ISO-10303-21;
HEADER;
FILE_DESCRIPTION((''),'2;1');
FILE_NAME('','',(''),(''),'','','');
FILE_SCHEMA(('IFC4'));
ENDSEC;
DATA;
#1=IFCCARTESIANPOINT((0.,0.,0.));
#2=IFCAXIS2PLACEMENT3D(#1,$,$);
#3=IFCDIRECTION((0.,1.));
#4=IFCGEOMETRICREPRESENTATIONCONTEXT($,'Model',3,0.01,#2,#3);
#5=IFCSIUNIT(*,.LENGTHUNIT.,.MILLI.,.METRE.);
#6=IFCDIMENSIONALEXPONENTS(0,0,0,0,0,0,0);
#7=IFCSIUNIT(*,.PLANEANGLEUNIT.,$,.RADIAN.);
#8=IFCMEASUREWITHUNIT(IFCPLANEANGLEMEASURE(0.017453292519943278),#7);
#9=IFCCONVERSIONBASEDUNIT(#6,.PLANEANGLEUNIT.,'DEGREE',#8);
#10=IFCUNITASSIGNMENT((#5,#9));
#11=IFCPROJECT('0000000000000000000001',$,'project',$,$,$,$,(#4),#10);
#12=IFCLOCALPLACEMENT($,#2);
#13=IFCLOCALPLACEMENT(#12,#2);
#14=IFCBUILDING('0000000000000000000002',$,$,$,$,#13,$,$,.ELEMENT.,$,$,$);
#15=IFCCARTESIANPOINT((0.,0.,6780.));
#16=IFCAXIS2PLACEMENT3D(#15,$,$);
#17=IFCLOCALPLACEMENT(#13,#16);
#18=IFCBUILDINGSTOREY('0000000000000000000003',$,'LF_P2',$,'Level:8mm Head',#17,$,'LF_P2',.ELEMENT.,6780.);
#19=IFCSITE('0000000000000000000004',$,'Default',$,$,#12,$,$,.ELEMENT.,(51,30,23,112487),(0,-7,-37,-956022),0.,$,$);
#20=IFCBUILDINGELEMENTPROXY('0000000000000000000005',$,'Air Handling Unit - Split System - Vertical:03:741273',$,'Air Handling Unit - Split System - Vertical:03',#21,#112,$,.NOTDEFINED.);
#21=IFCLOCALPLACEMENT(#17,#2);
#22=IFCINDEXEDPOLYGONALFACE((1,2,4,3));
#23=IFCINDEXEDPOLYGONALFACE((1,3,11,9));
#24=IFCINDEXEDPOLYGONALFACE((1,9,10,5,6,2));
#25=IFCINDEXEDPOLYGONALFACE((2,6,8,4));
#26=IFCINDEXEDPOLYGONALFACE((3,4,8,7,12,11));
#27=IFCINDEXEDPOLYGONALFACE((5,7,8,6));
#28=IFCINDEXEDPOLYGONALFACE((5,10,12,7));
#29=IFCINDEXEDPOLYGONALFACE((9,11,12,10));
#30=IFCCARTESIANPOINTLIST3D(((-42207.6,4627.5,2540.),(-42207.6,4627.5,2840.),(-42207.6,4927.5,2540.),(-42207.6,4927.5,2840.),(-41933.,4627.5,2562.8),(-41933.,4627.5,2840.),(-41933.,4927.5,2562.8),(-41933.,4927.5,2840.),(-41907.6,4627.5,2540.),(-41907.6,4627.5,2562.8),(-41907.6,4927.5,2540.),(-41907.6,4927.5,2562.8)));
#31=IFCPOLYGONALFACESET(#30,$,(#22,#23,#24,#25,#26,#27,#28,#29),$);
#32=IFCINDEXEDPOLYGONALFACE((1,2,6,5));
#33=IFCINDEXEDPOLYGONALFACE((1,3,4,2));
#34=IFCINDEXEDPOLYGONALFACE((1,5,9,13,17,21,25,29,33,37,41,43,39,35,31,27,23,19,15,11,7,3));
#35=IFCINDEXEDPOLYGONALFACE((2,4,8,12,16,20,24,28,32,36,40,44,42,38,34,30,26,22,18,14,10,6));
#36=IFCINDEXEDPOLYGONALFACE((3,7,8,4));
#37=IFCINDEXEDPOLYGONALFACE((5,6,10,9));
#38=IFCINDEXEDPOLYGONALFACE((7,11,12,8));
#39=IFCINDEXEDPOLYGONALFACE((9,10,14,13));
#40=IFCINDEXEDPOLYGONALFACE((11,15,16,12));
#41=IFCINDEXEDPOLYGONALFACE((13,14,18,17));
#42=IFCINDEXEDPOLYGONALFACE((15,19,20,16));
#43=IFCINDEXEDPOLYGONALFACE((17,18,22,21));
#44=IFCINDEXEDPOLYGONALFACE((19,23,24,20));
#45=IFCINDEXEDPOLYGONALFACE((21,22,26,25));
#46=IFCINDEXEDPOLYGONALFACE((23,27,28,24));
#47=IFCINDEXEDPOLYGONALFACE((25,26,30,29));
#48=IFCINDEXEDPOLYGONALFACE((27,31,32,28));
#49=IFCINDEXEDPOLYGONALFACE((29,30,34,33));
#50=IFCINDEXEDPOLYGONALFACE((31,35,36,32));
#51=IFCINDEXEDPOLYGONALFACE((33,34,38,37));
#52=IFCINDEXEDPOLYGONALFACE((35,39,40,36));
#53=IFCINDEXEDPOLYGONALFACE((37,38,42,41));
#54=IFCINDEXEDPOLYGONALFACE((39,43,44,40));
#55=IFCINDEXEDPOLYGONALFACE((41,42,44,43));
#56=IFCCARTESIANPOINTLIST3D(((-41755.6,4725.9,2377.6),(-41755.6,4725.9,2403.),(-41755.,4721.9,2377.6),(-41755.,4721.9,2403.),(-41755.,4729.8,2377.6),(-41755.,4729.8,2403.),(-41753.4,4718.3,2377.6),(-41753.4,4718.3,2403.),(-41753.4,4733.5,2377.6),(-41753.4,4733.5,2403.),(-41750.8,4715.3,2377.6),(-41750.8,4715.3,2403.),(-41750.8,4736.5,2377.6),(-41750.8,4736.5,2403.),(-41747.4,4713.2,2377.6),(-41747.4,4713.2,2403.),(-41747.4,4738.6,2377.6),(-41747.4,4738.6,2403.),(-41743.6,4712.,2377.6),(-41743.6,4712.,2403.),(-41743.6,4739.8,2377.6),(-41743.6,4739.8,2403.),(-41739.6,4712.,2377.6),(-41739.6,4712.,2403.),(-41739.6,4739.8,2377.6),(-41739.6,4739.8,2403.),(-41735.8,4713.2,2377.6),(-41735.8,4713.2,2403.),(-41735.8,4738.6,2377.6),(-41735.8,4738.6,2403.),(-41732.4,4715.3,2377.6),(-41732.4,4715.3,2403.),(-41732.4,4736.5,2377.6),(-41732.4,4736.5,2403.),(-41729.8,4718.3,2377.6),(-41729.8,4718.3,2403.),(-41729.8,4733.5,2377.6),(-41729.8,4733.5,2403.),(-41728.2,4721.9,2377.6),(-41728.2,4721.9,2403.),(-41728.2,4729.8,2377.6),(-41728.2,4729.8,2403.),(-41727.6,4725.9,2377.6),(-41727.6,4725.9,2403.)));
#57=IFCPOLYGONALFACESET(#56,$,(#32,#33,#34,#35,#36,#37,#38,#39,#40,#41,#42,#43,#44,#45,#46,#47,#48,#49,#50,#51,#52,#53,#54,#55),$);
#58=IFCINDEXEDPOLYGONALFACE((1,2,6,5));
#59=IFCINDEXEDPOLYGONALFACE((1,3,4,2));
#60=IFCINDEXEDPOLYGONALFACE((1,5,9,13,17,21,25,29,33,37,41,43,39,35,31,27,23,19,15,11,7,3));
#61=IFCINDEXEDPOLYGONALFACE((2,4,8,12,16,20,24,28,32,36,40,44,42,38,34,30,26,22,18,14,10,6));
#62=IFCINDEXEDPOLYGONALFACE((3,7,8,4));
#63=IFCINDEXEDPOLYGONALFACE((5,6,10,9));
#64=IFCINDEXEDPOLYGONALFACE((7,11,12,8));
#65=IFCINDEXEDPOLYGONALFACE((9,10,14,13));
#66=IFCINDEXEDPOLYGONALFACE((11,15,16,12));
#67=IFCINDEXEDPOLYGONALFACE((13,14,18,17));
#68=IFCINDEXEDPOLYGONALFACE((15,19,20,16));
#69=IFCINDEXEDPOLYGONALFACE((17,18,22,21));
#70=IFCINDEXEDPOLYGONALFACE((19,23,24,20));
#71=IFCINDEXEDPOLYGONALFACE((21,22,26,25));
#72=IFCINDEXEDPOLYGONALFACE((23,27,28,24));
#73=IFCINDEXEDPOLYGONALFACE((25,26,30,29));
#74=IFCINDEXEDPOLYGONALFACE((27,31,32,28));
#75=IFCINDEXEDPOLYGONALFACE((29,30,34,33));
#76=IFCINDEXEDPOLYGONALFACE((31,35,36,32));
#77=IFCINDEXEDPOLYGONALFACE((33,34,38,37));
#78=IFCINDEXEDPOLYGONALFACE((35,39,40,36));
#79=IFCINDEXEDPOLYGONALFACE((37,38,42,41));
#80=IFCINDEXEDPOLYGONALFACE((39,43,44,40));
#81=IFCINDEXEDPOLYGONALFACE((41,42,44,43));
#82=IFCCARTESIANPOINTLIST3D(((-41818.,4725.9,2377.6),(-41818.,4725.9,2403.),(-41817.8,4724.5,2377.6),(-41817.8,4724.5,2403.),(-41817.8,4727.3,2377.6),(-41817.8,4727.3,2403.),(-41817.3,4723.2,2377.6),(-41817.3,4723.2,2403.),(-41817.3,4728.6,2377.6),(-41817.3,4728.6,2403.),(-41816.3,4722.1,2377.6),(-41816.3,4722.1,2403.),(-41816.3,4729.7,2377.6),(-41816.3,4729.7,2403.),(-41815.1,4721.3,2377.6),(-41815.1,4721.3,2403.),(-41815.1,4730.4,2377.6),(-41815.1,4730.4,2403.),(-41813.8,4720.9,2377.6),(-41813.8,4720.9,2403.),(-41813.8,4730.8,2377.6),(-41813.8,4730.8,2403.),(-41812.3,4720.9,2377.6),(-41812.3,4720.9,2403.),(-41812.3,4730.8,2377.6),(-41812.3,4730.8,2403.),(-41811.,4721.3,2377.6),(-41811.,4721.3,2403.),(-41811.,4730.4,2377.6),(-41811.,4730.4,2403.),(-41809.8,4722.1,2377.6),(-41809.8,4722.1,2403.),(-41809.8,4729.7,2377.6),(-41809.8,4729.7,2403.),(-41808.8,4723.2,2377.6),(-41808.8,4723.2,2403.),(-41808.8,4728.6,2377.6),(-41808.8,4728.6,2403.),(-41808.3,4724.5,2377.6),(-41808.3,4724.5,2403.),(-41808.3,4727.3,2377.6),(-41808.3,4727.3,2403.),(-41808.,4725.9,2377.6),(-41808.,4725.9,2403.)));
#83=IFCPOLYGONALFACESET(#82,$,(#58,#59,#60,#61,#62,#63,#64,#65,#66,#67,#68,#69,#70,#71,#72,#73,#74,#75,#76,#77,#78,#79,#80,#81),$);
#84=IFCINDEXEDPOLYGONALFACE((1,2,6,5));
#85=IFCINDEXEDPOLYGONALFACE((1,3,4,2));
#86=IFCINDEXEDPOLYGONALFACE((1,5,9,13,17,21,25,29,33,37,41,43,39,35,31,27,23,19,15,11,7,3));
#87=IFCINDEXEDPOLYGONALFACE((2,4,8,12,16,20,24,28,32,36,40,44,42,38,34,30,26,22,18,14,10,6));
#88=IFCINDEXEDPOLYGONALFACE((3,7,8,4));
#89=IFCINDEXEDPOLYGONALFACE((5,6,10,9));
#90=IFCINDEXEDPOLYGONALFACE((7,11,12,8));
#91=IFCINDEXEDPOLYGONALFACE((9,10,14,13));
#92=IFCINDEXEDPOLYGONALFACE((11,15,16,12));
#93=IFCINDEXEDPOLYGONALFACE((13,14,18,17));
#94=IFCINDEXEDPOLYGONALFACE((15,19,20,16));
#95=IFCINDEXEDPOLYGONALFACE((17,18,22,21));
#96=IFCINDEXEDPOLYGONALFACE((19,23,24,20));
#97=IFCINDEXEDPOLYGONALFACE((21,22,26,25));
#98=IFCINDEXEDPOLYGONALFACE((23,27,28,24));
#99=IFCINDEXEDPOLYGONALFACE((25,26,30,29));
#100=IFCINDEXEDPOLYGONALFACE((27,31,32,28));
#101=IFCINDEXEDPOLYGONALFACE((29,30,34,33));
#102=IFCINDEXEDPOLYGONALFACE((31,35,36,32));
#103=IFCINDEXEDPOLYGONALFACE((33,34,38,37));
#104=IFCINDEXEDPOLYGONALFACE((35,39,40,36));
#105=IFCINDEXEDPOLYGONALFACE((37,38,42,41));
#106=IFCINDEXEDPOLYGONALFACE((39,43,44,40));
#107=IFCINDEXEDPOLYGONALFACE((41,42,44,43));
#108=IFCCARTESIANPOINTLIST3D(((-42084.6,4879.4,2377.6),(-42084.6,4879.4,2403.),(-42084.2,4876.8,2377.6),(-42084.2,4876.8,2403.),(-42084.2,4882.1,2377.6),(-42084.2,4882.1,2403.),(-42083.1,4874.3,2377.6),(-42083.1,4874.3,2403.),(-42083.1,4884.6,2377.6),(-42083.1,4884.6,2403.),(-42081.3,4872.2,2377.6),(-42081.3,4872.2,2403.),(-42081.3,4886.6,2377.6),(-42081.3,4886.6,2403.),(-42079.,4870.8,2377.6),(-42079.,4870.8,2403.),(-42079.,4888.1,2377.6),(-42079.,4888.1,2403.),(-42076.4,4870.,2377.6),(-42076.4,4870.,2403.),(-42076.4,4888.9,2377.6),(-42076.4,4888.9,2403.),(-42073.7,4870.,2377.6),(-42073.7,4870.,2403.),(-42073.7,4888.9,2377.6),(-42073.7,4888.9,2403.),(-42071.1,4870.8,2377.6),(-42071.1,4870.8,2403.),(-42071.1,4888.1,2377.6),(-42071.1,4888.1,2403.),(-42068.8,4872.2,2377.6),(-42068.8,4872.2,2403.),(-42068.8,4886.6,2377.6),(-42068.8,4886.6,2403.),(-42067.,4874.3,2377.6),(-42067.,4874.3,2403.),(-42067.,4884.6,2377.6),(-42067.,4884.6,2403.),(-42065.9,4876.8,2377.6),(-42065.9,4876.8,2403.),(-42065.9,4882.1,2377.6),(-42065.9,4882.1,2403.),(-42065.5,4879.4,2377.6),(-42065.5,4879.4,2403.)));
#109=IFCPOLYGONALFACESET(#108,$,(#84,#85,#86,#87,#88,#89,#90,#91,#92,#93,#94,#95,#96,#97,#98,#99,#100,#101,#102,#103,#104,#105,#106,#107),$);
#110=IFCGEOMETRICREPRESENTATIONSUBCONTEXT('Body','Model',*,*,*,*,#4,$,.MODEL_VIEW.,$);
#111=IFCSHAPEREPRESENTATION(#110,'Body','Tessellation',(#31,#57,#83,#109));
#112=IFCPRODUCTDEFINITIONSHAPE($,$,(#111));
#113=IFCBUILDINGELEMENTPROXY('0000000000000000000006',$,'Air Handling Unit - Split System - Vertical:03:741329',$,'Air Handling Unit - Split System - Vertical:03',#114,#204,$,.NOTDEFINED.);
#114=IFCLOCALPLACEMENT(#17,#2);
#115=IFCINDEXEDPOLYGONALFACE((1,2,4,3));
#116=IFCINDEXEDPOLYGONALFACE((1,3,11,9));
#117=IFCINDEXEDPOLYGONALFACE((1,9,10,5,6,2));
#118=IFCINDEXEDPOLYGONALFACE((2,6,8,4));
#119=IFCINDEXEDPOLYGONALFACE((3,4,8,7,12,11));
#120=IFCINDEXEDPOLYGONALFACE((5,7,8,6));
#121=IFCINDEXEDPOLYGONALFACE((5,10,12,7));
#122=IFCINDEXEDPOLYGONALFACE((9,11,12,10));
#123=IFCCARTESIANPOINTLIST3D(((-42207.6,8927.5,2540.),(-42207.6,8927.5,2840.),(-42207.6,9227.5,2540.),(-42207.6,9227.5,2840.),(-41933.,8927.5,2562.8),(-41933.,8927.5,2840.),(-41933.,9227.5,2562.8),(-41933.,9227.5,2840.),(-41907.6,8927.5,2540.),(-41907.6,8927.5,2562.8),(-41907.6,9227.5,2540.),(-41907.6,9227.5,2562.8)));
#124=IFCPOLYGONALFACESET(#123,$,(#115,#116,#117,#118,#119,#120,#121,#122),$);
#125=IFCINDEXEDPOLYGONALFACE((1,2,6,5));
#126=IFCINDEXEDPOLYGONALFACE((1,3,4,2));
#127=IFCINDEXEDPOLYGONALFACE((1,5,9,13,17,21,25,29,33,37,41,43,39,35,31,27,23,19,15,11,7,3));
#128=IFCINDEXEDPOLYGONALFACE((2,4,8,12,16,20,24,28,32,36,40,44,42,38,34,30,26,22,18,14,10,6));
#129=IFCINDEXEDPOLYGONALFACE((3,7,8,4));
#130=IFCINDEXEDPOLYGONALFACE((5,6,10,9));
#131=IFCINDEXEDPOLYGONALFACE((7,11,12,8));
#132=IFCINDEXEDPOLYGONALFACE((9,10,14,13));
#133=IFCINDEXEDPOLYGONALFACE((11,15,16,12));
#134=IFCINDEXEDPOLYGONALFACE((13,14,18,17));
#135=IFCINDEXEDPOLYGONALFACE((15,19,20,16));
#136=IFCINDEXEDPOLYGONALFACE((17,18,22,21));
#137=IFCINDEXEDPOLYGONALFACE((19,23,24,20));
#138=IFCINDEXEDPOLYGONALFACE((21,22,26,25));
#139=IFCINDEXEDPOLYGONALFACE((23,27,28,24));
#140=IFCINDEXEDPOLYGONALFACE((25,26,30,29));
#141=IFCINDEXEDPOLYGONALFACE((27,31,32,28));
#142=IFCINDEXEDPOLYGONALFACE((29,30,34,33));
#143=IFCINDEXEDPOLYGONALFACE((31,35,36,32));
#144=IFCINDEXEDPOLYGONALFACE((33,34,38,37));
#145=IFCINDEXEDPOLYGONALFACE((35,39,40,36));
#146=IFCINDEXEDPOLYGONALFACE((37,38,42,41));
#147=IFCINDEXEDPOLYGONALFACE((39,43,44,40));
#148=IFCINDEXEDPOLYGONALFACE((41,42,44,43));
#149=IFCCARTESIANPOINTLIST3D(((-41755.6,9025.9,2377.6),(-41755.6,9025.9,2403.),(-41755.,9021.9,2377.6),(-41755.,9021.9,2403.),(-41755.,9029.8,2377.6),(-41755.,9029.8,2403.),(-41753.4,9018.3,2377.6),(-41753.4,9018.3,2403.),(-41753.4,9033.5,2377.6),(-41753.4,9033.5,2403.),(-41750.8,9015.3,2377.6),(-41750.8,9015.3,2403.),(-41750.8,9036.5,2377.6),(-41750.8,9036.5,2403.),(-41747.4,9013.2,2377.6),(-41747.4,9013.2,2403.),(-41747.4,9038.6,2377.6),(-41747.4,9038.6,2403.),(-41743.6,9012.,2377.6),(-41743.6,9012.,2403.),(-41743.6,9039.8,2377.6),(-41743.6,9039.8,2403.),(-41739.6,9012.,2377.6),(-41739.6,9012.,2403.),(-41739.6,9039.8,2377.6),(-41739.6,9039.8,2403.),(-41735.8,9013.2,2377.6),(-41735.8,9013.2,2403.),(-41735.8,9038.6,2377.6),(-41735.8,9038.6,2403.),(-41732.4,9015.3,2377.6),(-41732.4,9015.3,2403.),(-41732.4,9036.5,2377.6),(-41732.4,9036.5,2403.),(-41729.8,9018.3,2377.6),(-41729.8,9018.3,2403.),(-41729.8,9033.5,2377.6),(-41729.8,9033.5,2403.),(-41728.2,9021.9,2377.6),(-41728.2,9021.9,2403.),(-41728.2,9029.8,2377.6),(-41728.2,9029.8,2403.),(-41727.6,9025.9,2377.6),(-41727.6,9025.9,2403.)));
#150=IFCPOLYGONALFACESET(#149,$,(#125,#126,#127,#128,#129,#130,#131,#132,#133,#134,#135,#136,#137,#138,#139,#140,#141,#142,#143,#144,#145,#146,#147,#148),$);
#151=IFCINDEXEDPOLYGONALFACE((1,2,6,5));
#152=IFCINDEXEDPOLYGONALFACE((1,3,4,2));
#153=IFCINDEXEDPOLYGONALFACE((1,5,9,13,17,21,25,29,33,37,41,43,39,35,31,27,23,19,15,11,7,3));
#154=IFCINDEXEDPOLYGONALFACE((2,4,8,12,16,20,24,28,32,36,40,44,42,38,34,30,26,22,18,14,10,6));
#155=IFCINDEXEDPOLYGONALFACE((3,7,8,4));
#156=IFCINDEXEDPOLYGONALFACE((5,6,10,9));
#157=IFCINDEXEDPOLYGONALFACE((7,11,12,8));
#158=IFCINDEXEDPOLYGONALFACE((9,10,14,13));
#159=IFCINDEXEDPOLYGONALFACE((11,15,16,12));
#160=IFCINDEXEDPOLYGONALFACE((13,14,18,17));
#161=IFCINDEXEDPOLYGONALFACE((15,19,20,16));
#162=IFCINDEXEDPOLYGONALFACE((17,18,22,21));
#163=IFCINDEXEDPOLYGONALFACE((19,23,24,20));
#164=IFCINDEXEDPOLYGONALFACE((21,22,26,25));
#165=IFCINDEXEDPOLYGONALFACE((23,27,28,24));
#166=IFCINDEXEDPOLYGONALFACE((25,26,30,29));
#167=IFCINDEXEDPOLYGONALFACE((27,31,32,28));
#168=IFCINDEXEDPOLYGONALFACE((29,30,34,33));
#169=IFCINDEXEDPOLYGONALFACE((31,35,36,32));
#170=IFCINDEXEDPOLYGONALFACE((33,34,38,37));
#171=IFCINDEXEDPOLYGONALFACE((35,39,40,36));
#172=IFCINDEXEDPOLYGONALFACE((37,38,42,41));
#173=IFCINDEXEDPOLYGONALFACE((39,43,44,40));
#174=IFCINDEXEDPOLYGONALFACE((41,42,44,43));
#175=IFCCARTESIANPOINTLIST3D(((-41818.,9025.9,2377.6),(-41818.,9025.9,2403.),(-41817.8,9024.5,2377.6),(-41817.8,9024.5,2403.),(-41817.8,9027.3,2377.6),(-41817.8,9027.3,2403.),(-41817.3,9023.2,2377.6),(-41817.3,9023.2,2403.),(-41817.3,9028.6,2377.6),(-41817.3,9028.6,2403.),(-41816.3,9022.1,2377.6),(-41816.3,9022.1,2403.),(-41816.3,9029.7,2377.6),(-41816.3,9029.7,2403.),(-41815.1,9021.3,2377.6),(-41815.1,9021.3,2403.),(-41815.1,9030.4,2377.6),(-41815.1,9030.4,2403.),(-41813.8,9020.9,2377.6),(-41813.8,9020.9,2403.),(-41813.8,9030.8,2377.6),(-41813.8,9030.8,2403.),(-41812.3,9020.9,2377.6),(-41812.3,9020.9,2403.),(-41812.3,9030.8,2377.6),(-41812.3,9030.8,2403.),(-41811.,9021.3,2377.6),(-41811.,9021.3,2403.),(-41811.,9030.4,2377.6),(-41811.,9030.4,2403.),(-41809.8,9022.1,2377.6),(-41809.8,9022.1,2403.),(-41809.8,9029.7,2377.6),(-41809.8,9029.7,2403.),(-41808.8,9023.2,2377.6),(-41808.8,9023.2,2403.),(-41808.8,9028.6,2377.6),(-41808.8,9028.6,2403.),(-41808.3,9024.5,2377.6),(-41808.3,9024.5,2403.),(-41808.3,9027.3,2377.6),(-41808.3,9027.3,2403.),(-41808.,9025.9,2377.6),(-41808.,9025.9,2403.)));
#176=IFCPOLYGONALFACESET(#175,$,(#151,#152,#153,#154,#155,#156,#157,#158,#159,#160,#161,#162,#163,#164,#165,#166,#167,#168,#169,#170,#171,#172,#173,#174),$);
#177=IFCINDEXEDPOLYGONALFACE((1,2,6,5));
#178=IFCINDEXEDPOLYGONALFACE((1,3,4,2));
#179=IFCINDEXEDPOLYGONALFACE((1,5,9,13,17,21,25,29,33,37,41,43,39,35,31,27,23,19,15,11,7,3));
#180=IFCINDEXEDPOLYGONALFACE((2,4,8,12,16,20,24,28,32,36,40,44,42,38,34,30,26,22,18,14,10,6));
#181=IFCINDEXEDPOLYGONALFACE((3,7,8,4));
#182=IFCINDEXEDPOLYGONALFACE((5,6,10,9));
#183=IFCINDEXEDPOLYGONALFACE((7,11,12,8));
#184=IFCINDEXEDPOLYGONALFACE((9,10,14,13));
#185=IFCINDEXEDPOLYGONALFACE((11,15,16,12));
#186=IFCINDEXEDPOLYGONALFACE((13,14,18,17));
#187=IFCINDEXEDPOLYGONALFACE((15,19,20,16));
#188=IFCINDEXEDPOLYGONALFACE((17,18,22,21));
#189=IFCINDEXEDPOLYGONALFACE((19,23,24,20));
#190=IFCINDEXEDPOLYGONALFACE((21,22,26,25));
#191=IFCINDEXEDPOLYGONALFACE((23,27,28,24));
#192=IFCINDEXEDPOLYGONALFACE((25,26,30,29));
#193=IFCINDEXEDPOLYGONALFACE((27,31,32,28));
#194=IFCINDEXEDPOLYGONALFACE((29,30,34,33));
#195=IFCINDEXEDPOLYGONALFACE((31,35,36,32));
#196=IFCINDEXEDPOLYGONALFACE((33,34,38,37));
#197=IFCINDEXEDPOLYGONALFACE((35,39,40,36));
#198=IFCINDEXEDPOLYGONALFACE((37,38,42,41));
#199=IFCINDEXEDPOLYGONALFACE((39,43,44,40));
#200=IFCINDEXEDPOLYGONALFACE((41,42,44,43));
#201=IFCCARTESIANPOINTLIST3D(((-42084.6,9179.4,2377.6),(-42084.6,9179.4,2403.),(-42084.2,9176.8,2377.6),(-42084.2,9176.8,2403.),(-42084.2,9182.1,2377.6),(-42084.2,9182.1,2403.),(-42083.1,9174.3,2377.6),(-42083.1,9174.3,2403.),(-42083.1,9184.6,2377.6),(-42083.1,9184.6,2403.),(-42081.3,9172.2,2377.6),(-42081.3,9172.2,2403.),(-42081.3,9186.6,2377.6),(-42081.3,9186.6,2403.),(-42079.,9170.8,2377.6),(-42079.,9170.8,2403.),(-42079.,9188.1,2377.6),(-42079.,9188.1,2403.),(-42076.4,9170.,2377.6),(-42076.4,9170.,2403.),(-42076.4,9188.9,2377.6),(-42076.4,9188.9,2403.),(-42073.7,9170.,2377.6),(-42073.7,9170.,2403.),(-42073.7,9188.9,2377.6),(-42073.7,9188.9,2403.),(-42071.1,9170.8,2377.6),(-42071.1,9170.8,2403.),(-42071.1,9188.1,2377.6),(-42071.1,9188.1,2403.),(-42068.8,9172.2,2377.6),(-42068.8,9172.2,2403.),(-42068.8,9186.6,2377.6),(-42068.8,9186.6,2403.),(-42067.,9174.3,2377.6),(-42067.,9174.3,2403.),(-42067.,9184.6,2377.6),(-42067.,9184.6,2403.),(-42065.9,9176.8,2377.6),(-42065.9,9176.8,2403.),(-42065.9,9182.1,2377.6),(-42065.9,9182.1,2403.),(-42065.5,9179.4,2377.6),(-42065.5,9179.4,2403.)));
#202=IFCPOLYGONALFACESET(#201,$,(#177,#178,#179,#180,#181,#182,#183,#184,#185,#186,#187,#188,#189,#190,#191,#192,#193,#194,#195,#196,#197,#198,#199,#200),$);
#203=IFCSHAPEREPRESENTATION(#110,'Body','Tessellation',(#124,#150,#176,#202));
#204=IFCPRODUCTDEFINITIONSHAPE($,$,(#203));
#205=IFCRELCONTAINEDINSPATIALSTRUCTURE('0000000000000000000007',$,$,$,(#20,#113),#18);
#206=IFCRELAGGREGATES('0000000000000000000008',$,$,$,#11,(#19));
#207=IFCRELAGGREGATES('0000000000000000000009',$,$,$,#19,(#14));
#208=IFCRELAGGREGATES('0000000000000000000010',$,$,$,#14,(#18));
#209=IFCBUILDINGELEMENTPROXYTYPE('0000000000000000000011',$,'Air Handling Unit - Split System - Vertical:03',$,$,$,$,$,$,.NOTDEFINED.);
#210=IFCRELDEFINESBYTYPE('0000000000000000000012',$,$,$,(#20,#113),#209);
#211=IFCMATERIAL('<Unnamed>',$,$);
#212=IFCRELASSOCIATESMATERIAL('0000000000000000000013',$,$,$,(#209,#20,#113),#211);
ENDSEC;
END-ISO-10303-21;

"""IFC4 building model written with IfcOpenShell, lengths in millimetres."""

from ifc_helpers import new_model, entity, si_unit, converted_unit, direction, frame, origin, place, context, subcontext, project, spatial, arc, indexed_curve, outline, extrude, source, transform, mapped, material, type_object, type_shapes, element, save


model = new_model("IFC4")

# Units and contexts
model_context = context("Model", 3, precision=0.01, world=origin(), true_north=direction((0.0, 1.0)))
body_context = subcontext(model_context, "Body", "Model", "MODEL_VIEW")
ifc_project = project(units=[si_unit("LENGTHUNIT", "METRE", prefix="MILLI"), converted_unit("PLANEANGLEUNIT", "DEGREE", entity("IfcPlaneAngleMeasure", 0.017453292519943278), si_unit("PLANEANGLEUNIT", "RADIAN"), dimensions=[0, 0, 0, 0, 0, 0, 0])], contexts=[model_context])

# Site, building, storey
site_placement = place(None, origin())
site = spatial("IfcSite", under=ifc_project, at=site_placement, Name="Default", CompositionType="ELEMENT", RefLatitude=(51, 30, 23, 112487), RefLongitude=(0, -7, -37, -956022), RefElevation=0.0)
building_placement = place(site_placement, origin())
building = spatial("IfcBuilding", under=site, at=building_placement, CompositionType="ELEMENT")
storey_placement = place(building_placement, frame((0.0, 0.0, 6780.0)))
storey = spatial("IfcBuildingStorey", under=building, at=storey_placement, Name="LF_P2", ObjectType="Level:8mm Head", LongName="LF_P2", CompositionType="ELEMENT", Elevation=6780.0)

# Shared definitions
ifc_material = material(Name="<Unnamed>")

# Building element proxies
building_element_proxy_type_1 = type_object("IfcBuildingElementProxyType", Name="Air Handling Unit - Split System - Vertical:03", PredefinedType="NOTDEFINED", material=ifc_material)
shared_shape_1 = source(origin(), body_context, "Body", "SweptSolid", [
    extrude(outline(indexed_curve([(-191.5, -107.6), (108.5, -107.6), (108.5, -84.8), (83.1, -84.8), (83.1, 192.4), (-191.5, 192.4), (-191.5, -107.6)], self_intersect=False)), frame((-150.0, 42.4, 191.5), z_axis=(1.0, 0.0, 0.0), x_axis=(0.0, 0.0, 1.0)), (0.0, 0.0, 1.0), 300.0),
    extrude(outline(indexed_curve([(-14.0, 0.0), (0.0, -14.0), (14.0, 0.0), (0.0, 14.0)], segments=[arc(1, 2, 3), arc(3, 4, 1)], self_intersect=False)), frame((51.6, 287.0, 466.0), z_axis=(0.0, 1.0, 0.0), x_axis=(0.0, 0.0, -1.0)), (0.0, 0.0, 1.0), 25.4),
    extrude(outline(indexed_curve([(-5.0, 0.0), (0.0, -5.0), (5.0, 0.0), (0.0, 5.0)], segments=[arc(1, 2, 3), arc(3, 4, 1)], self_intersect=False)), frame((51.6, 287.0, 394.6), z_axis=(0.0, 1.0, 0.0), x_axis=(0.0, 0.0, -1.0)), (0.0, 0.0, 1.0), 25.4),
    extrude(outline(indexed_curve([(-9.5, 0.0), (0.0, -9.5), (9.5, 0.0), (0.0, 9.5)], segments=[arc(1, 2, 3), arc(3, 4, 1)], self_intersect=False)), frame((-102.0, 287.0, 132.6), z_axis=(0.0, 1.0, 0.0), x_axis=(0.0, 0.0, -1.0)), (0.0, 0.0, 1.0), 25.4),
])
type_shapes(building_element_proxy_type_1, [shared_shape_1])
for number, where, z_axis, x_axis, name in (
    (1, (-42207.6, 4777.5, 2690.0), (1.0, 0.0, 0.0), (0.0, -1.0, 0.0), "Air Handling Unit - Split System - Vertical:03:741273"),
    (2, (-42207.6, 9077.5, 2690.0), (1.0, 0.0, 0.0), (0.0, -1.0, 0.0), "Air Handling Unit - Split System - Vertical:03:741329"),
):
    element("IfcBuildingElementProxy", number, at=place(storey_placement, frame(where, z_axis=z_axis, x_axis=x_axis)), inside=storey, type_object=building_element_proxy_type_1, material=ifc_material, Name=name, ObjectType="Air Handling Unit - Split System - Vertical:03", PredefinedType="NOTDEFINED", context=body_context, shape_type="MappedRepresentation", body=[
        mapped(shared_shape_1, transform((0.0, 0.0, 0.0), scale=1.0)),
    ])

save(model, "model.ifc")
